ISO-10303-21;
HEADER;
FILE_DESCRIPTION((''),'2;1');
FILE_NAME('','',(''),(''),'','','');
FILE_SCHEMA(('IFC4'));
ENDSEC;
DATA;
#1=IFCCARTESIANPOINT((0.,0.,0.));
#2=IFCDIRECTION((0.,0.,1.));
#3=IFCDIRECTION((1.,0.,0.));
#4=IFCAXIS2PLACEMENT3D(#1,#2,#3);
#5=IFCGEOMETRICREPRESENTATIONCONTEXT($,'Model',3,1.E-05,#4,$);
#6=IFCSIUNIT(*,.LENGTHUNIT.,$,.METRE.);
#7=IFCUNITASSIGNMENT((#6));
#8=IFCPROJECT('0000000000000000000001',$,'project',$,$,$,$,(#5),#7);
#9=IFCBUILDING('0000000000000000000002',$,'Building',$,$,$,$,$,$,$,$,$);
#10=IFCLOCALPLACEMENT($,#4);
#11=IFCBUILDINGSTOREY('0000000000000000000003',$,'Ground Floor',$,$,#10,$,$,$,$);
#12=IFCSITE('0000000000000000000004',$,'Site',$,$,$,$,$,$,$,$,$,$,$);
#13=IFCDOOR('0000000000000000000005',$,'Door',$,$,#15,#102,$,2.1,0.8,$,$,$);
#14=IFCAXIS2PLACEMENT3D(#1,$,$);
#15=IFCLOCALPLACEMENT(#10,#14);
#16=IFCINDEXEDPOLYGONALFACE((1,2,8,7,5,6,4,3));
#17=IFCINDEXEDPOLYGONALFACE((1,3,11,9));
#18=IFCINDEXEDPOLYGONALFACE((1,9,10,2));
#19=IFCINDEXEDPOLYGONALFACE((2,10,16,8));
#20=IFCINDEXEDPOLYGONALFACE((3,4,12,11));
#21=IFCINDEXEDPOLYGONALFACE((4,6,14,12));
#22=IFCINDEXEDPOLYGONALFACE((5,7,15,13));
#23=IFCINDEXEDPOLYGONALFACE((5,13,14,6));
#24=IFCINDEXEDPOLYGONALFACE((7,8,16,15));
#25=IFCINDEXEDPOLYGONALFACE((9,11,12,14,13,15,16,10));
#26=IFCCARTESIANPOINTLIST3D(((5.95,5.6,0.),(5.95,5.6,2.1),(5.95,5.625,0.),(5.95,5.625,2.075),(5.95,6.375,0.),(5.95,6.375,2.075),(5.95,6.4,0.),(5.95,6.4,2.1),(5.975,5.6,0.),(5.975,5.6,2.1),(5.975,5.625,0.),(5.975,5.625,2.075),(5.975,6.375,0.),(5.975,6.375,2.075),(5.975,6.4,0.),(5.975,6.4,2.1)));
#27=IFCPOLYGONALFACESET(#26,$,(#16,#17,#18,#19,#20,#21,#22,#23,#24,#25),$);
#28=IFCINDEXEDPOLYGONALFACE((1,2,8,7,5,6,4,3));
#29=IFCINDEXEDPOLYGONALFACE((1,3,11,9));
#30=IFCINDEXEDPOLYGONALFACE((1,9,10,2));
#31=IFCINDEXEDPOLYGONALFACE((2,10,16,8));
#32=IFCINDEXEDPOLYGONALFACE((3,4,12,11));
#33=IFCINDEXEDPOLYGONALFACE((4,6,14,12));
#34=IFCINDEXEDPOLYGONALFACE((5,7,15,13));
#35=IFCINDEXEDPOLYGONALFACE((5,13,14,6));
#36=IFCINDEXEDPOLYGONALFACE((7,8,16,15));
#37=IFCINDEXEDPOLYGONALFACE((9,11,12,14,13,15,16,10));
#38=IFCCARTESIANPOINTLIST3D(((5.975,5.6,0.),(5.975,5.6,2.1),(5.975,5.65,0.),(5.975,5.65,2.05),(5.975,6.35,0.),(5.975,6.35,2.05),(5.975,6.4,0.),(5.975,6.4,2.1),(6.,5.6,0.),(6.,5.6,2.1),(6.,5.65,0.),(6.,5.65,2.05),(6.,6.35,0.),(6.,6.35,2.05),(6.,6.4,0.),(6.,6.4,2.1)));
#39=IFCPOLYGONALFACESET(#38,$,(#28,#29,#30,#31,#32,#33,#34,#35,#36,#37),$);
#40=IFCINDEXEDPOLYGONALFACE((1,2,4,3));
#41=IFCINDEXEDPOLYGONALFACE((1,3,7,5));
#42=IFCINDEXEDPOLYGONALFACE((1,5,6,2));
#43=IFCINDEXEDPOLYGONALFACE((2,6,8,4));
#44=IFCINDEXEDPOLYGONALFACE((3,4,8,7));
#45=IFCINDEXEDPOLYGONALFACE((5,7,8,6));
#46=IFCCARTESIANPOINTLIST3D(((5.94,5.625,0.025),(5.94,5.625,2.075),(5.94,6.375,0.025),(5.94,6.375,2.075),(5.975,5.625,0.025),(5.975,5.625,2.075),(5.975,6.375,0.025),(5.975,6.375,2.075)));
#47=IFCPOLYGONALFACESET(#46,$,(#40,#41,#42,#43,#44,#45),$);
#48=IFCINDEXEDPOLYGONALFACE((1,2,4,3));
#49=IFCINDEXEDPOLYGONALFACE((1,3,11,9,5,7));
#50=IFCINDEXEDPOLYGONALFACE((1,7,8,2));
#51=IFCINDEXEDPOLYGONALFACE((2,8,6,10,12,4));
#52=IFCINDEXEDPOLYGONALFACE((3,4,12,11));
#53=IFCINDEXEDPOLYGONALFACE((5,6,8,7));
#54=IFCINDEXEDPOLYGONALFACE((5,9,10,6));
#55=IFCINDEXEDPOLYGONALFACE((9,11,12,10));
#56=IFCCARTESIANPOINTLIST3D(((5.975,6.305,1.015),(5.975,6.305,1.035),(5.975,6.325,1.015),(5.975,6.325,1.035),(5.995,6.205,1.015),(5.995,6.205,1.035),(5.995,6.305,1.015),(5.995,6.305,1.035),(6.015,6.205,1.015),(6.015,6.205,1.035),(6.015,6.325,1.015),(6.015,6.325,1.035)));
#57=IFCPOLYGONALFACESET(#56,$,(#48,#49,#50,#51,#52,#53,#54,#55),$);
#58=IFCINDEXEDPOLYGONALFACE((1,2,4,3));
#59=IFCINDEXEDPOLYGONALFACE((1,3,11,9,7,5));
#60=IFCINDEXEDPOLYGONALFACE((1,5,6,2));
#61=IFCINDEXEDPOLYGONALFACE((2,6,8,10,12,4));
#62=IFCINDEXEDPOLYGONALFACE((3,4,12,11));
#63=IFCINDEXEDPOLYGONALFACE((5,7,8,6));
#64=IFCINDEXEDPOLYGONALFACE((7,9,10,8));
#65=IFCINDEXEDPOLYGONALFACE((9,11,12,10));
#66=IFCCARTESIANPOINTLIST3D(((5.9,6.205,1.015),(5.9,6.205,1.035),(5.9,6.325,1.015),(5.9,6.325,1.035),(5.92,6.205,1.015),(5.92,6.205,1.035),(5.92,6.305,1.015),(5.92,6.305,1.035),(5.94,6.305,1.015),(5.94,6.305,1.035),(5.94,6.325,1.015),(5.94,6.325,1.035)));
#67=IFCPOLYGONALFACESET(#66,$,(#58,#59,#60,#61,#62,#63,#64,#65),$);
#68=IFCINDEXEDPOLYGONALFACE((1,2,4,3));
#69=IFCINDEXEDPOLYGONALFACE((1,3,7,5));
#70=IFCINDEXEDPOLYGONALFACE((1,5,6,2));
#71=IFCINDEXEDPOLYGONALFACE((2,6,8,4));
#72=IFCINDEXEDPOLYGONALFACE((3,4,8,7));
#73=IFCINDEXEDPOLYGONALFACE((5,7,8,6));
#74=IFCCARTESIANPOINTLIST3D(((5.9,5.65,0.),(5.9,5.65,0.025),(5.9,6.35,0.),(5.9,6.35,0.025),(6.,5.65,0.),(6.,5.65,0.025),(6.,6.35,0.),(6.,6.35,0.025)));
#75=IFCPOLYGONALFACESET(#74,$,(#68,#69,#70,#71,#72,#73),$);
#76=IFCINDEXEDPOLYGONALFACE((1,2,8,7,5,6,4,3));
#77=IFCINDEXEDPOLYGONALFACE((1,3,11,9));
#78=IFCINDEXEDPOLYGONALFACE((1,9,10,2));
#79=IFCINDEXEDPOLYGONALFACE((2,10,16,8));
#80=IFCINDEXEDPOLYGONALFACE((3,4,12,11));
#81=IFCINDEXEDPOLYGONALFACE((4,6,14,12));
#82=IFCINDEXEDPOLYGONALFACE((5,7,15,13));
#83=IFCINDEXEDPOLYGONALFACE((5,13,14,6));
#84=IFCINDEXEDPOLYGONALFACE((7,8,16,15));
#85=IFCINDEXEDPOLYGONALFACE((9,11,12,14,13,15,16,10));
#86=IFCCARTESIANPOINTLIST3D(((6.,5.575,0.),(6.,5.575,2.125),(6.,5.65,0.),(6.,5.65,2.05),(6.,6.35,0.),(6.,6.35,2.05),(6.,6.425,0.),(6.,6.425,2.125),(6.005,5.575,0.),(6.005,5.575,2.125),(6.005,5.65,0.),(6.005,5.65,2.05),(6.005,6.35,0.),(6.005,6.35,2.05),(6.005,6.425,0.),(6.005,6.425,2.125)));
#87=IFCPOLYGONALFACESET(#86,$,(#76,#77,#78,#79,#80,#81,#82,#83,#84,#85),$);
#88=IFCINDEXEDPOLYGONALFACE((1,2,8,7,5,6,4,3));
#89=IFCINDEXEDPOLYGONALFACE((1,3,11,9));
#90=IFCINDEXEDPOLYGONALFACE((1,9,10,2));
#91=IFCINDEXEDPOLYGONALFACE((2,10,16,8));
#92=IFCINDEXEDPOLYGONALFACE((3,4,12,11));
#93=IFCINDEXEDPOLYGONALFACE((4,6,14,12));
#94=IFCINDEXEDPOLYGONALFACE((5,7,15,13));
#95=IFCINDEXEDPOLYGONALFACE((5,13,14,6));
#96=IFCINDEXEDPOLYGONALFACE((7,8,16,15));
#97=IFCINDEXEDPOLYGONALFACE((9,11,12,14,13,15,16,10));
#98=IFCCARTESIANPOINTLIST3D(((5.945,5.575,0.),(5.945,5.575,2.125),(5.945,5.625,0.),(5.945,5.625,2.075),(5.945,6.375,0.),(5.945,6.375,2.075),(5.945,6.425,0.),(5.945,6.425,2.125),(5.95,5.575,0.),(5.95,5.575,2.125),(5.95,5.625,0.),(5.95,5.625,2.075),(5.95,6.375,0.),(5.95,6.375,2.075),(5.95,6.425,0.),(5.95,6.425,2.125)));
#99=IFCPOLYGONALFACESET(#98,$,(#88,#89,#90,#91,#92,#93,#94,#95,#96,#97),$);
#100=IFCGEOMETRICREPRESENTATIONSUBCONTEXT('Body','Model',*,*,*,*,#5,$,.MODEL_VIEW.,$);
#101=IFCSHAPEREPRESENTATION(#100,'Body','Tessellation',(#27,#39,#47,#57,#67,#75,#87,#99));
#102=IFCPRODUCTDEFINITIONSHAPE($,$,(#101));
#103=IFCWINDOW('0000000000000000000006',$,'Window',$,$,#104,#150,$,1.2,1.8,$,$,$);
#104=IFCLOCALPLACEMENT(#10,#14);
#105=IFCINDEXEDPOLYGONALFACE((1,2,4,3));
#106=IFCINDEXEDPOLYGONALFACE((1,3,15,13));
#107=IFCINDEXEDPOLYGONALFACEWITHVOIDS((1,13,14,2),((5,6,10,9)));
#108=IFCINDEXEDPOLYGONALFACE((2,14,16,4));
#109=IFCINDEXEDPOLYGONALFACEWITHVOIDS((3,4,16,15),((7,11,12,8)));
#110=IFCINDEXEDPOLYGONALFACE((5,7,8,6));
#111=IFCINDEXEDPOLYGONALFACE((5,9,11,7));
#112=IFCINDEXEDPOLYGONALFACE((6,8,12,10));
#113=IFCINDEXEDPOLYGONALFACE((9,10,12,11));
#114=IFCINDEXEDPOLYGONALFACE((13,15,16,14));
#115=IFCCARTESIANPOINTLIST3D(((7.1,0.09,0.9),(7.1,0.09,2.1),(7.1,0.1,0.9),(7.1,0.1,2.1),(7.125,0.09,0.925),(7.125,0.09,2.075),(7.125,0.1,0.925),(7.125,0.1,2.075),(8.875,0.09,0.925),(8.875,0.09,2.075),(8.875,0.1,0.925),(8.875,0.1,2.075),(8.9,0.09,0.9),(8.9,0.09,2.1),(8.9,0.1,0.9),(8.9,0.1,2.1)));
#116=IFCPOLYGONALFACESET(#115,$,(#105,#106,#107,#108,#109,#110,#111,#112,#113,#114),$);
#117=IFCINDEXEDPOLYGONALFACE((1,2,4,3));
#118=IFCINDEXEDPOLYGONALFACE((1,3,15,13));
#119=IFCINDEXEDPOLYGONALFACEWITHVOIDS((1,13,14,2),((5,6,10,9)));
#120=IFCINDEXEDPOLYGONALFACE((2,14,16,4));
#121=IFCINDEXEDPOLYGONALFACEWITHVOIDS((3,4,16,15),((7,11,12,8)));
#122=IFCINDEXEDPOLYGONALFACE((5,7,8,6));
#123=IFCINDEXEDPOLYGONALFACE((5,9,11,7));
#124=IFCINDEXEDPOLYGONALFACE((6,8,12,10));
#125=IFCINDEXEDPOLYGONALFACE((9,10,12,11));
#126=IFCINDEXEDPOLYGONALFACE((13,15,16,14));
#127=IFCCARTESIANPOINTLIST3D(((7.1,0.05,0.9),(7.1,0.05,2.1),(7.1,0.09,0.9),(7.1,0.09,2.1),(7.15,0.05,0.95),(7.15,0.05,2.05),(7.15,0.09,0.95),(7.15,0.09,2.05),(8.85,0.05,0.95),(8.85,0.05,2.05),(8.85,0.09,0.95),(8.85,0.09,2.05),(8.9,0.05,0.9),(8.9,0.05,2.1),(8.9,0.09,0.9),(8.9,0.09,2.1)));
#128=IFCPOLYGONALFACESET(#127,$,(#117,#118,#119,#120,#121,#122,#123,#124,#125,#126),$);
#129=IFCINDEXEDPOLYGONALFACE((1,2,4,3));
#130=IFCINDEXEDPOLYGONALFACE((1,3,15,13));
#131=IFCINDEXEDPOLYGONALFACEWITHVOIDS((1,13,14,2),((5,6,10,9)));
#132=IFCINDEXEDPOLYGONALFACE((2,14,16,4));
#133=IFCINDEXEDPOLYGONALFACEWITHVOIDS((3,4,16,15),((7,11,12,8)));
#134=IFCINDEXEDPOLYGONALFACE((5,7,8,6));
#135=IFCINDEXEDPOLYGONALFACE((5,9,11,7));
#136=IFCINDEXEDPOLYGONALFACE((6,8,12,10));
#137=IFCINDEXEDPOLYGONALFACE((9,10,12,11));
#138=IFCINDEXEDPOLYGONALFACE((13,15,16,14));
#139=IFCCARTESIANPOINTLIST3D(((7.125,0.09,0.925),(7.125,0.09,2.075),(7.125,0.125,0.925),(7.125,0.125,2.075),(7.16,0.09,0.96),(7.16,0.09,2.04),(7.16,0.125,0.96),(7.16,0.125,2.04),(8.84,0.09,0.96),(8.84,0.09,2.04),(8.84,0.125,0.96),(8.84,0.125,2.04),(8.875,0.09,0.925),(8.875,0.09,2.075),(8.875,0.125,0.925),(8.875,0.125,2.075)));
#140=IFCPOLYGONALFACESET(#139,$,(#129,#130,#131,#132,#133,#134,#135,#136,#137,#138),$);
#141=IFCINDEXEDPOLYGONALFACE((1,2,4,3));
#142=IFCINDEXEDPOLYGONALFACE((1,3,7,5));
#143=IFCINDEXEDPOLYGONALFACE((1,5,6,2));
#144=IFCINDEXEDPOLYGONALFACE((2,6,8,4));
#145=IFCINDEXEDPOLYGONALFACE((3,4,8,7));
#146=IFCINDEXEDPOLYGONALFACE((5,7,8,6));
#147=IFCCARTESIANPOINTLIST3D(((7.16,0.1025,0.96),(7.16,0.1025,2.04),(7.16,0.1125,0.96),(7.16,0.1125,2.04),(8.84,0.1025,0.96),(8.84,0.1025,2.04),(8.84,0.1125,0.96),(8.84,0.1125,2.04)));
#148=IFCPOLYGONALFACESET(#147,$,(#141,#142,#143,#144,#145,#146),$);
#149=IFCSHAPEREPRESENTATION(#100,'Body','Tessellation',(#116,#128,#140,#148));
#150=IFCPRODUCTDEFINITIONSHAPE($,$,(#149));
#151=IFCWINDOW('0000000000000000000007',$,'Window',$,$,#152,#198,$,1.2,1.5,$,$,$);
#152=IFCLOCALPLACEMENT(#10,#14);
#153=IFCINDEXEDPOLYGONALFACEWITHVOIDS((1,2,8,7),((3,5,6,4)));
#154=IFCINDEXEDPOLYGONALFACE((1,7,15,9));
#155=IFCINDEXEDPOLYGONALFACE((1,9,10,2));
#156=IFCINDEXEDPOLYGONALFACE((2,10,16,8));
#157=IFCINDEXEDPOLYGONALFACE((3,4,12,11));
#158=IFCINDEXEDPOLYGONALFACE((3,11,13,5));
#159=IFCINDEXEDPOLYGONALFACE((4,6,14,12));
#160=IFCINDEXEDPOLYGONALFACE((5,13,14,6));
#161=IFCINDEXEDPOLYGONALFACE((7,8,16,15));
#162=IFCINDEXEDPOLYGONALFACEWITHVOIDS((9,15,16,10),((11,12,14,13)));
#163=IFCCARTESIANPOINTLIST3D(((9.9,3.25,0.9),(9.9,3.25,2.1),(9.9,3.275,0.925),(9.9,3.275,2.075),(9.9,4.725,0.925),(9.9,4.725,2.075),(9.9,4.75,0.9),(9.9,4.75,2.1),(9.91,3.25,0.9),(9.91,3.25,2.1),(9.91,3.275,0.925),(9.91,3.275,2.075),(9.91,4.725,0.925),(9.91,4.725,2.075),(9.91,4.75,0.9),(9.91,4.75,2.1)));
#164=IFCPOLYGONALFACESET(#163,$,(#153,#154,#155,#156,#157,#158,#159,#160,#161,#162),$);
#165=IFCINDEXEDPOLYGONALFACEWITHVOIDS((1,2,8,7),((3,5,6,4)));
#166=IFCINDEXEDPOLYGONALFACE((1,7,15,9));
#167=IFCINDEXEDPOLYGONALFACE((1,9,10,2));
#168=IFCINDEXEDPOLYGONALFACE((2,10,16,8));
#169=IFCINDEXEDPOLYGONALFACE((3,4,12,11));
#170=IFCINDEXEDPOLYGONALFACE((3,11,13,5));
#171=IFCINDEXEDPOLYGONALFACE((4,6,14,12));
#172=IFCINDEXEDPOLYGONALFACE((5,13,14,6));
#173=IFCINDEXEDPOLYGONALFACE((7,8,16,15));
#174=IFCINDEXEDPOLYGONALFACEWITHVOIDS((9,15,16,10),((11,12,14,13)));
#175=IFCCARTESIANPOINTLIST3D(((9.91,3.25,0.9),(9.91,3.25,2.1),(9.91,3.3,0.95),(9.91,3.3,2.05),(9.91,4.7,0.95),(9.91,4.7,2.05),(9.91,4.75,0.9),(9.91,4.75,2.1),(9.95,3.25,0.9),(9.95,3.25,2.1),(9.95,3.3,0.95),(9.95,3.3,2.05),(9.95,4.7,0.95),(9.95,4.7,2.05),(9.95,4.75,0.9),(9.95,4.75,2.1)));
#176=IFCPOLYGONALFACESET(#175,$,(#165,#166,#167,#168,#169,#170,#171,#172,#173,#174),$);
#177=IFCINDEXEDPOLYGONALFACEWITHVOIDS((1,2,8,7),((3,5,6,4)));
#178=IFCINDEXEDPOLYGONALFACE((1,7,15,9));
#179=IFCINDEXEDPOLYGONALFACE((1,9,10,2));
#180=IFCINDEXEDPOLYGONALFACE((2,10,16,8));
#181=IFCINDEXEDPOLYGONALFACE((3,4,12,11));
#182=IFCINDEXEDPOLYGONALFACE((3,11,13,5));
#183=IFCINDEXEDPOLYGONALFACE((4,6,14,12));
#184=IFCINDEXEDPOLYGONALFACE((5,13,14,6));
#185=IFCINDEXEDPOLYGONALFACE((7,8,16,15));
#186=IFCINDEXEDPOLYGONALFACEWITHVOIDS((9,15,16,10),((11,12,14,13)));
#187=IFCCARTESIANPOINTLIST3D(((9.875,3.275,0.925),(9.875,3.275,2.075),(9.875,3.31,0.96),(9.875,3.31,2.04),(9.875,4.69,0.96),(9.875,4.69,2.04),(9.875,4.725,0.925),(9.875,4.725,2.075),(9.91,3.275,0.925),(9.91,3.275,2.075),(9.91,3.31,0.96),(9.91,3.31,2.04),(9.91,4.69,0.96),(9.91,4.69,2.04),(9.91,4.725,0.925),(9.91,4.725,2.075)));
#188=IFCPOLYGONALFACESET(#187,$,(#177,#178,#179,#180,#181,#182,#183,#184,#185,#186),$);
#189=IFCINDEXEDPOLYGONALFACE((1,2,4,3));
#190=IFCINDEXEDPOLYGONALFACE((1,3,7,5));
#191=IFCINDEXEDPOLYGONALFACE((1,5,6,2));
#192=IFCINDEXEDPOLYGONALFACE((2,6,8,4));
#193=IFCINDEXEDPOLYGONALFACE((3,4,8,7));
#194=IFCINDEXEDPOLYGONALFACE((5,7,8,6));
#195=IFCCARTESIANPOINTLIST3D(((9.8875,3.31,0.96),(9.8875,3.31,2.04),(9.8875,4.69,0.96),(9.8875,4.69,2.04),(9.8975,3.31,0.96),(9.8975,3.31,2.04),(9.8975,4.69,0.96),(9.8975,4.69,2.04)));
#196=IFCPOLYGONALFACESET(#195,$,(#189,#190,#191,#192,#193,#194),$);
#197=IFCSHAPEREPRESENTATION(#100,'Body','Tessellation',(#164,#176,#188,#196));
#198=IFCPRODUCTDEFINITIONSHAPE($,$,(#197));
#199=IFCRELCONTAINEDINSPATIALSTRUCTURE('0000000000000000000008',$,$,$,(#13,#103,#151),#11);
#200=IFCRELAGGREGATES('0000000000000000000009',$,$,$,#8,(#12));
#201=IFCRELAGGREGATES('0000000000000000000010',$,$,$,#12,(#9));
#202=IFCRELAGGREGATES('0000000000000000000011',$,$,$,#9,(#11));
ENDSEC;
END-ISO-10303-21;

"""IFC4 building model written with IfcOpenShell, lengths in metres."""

from ifc_helpers import new_model, si_unit, frame, origin_with_axes, place, context, subcontext, project, spatial, line, indexed_curve, outline, extrude, element, save


model = new_model("IFC4")

# Units and contexts
model_context = context("Model", 3, precision=1e-05, world=origin_with_axes())
body_context = subcontext(model_context, "Body", "Model", "MODEL_VIEW")
ifc_project = project(units=[si_unit("LENGTHUNIT", "METRE")], contexts=[model_context])

# Site, building, storey
site = spatial("IfcSite", under=ifc_project, Name="Site")
building = spatial("IfcBuilding", under=site, Name="Building")
storey_placement = place(None, origin_with_axes())
storey = spatial("IfcBuildingStorey", under=building, at=storey_placement, Name="Ground Floor")

# Door
door_1_placement = place(storey_placement, frame((6.0, 5.6, 0.0), z_axis=(0.0, 0.0, 1.0), x_axis=(0.0, 1.0, 0.0)))
element("IfcDoor", 1, at=door_1_placement, inside=storey, Name="Door", OverallHeight=2.1, OverallWidth=0.8, context=body_context, shape_type="SweptSolid", body=[
    extrude(outline(indexed_curve([(0.0, 0.0), (0.0, 2.1), (0.8, 2.1), (0.8, 0.0), (0.775, 0.0), (0.775, 2.075), (0.025, 2.075), (0.025, 0.0)], segments=[line(1, 2, 3, 4, 5, 6, 7, 8, 1)])), frame((0.0, 0.025, 0.0), z_axis=(0.0, -1.0, 0.0), x_axis=(1.0, 0.0, 0.0)), (0.0, 0.0, -1.0), 0.025),
    extrude(outline(indexed_curve([(0.0, 0.0), (0.0, 2.1), (0.8, 2.1), (0.8, 0.0), (0.75, 0.0), (0.75, 2.05), (0.05, 2.05), (0.05, 0.0)], segments=[line(1, 2, 3, 4, 5, 6, 7, 8, 1)])), frame((0.0, 0.0, 0.0), z_axis=(0.0, -1.0, 0.0), x_axis=(1.0, 0.0, 0.0)), (0.0, 0.0, -1.0), 0.025),
    extrude(outline(indexed_curve([(0.0, 0.0), (0.75, 0.0), (0.75, 0.035), (0.0, 0.035)], segments=[line(1, 2, 3, 4, 1)])), frame((0.025, 0.025, 0.025), z_axis=(0.0, 0.0, 1.0), x_axis=(1.0, 0.0, 0.0)), (0.0, 0.0, 1.0), 2.05),
    extrude(outline(indexed_curve([(0.0, 0.0), (0.0, -0.04), (-0.12, -0.04), (-0.12, -0.02), (-0.02, -0.02), (-0.02, 0.0)], segments=[line(1, 2, 3, 4, 5, 6, 1)])), frame((0.725, 0.025, 1.015), z_axis=(0.0, 0.0, 1.0), x_axis=(1.0, 0.0, 0.0)), (0.0, 0.0, 1.0), 0.02),
    extrude(outline(indexed_curve([(0.0, 0.0), (0.0, 0.04), (-0.12, 0.04), (-0.12, 0.02), (-0.02, 0.02), (-0.02, 0.0)], segments=[line(1, 2, 3, 4, 5, 6, 1)])), frame((0.725, 0.06, 1.015), z_axis=(0.0, 0.0, 1.0), x_axis=(1.0, 0.0, 0.0)), (0.0, 0.0, 1.0), 0.02),
    extrude(outline(indexed_curve([(0.0, 0.0), (0.7, 0.0), (0.7, 0.1), (0.0, 0.1)], segments=[line(1, 2, 3, 4, 1)])), frame((0.05, 0.0, 0.0), z_axis=(0.0, 0.0, 1.0), x_axis=(1.0, 0.0, 0.0)), (0.0, 0.0, 1.0), 0.025),
    extrude(outline(indexed_curve([(0.0, 0.0), (0.0, 2.125), (0.85, 2.125), (0.85, 0.0), (0.775, 0.0), (0.775, 2.05), (0.075, 2.05), (0.075, 0.0)], segments=[line(1, 2, 3, 4, 5, 6, 7, 8, 1)])), frame((-0.025, -0.005, 0.0), z_axis=(0.0, -1.0, 0.0), x_axis=(1.0, 0.0, 0.0)), (0.0, 0.0, -1.0), 0.005),
    extrude(outline(indexed_curve([(0.0, 0.0), (0.0, 2.125), (0.85, 2.125), (0.85, 0.0), (0.8, 0.0), (0.8, 2.075), (0.05, 2.075), (0.05, 0.0)], segments=[line(1, 2, 3, 4, 5, 6, 7, 8, 1)])), frame((-0.025, 0.05, 0.0), z_axis=(0.0, -1.0, 0.0), x_axis=(1.0, 0.0, 0.0)), (0.0, 0.0, -1.0), 0.005),
])

# Windows
window_placement = place(storey_placement, frame((7.1, 0.0, 0.9), z_axis=(0.0, 0.0, 1.0), x_axis=(1.0, 0.0, 0.0)))
element("IfcWindow", 2, at=window_placement, inside=storey, Name="Window", OverallHeight=1.2, OverallWidth=1.8, context=body_context, shape_type="SweptSolid", body=[
    extrude(outline(indexed_curve([(0.0, 0.0), (1.8, 0.0), (1.8, 1.2), (0.0, 1.2)], segments=[line(1, 2, 3, 4, 1)]), holes=[indexed_curve([(0.025, 0.025), (1.775, 0.025), (1.775, 1.175), (0.025, 1.175)], segments=[line(1, 2, 3, 4, 1)])]), frame((0.0, 0.09, 0.0), z_axis=(0.0, -1.0, 0.0), x_axis=(1.0, 0.0, 0.0)), (0.0, 0.0, -1.0), 0.01),
    extrude(outline(indexed_curve([(0.0, 0.0), (1.8, 0.0), (1.8, 1.2), (0.0, 1.2)], segments=[line(1, 2, 3, 4, 1)]), holes=[indexed_curve([(0.05, 0.05), (1.75, 0.05), (1.75, 1.15), (0.05, 1.15)], segments=[line(1, 2, 3, 4, 1)])]), frame((0.0, 0.05, 0.0), z_axis=(0.0, -1.0, 0.0), x_axis=(1.0, 0.0, 0.0)), (0.0, 0.0, -1.0), 0.04),
    extrude(outline(indexed_curve([(0.0, 0.0), (1.75, 0.0), (1.75, 1.15), (0.0, 1.15)], segments=[line(1, 2, 3, 4, 1)]), holes=[indexed_curve([(0.035, 0.035), (1.715, 0.035), (1.715, 1.115), (0.035, 1.115)], segments=[line(1, 2, 3, 4, 1)])]), frame((0.025, 0.09, 0.025), z_axis=(0.0, -1.0, 0.0), x_axis=(1.0, 0.0, 0.0)), (0.0, 0.0, -1.0), 0.035),
    extrude(outline(indexed_curve([(0.035, 0.035), (1.715, 0.035), (1.715, 1.115), (0.035, 1.115)], segments=[line(1, 2, 3, 4, 1)])), frame((0.025, 0.1025, 0.025), z_axis=(0.0, -1.0, 0.0), x_axis=(1.0, 0.0, 0.0)), (0.0, 0.0, -1.0), 0.01),
])
for number, where, z_axis, x_axis, name in (
    (3, (10.0, 3.25, 0.9), (0.0, 0.0, 1.0), (0.0, 1.0, 0.0), "Window"),
):
    element("IfcWindow", number, at=place(storey_placement, frame(where, z_axis=z_axis, x_axis=x_axis)), inside=storey, Name=name, OverallHeight=1.2, OverallWidth=1.5, context=body_context, shape_type="SweptSolid", body=[
        extrude(outline(indexed_curve([(0.0, 0.0), (1.5, 0.0), (1.5, 1.2), (0.0, 1.2)], segments=[line(1, 2, 3, 4, 1)]), holes=[indexed_curve([(0.025, 0.025), (1.475, 0.025), (1.475, 1.175), (0.025, 1.175)], segments=[line(1, 2, 3, 4, 1)])]), frame((0.0, 0.09, 0.0), z_axis=(0.0, -1.0, 0.0), x_axis=(1.0, 0.0, 0.0)), (0.0, 0.0, -1.0), 0.01),
        extrude(outline(indexed_curve([(0.0, 0.0), (1.5, 0.0), (1.5, 1.2), (0.0, 1.2)], segments=[line(1, 2, 3, 4, 1)]), holes=[indexed_curve([(0.05, 0.05), (1.45, 0.05), (1.45, 1.15), (0.05, 1.15)], segments=[line(1, 2, 3, 4, 1)])]), frame((0.0, 0.05, 0.0), z_axis=(0.0, -1.0, 0.0), x_axis=(1.0, 0.0, 0.0)), (0.0, 0.0, -1.0), 0.04),
        extrude(outline(indexed_curve([(0.0, 0.0), (1.45, 0.0), (1.45, 1.15), (0.0, 1.15)], segments=[line(1, 2, 3, 4, 1)]), holes=[indexed_curve([(0.035, 0.035), (1.415, 0.035), (1.415, 1.115), (0.035, 1.115)], segments=[line(1, 2, 3, 4, 1)])]), frame((0.025, 0.09, 0.025), z_axis=(0.0, -1.0, 0.0), x_axis=(1.0, 0.0, 0.0)), (0.0, 0.0, -1.0), 0.035),
        extrude(outline(indexed_curve([(0.035, 0.035), (1.415, 0.035), (1.415, 1.115), (0.035, 1.115)], segments=[line(1, 2, 3, 4, 1)])), frame((0.025, 0.1025, 0.025), z_axis=(0.0, -1.0, 0.0), x_axis=(1.0, 0.0, 0.0)), (0.0, 0.0, -1.0), 0.01),
    ])

save(model, "model.ifc")
